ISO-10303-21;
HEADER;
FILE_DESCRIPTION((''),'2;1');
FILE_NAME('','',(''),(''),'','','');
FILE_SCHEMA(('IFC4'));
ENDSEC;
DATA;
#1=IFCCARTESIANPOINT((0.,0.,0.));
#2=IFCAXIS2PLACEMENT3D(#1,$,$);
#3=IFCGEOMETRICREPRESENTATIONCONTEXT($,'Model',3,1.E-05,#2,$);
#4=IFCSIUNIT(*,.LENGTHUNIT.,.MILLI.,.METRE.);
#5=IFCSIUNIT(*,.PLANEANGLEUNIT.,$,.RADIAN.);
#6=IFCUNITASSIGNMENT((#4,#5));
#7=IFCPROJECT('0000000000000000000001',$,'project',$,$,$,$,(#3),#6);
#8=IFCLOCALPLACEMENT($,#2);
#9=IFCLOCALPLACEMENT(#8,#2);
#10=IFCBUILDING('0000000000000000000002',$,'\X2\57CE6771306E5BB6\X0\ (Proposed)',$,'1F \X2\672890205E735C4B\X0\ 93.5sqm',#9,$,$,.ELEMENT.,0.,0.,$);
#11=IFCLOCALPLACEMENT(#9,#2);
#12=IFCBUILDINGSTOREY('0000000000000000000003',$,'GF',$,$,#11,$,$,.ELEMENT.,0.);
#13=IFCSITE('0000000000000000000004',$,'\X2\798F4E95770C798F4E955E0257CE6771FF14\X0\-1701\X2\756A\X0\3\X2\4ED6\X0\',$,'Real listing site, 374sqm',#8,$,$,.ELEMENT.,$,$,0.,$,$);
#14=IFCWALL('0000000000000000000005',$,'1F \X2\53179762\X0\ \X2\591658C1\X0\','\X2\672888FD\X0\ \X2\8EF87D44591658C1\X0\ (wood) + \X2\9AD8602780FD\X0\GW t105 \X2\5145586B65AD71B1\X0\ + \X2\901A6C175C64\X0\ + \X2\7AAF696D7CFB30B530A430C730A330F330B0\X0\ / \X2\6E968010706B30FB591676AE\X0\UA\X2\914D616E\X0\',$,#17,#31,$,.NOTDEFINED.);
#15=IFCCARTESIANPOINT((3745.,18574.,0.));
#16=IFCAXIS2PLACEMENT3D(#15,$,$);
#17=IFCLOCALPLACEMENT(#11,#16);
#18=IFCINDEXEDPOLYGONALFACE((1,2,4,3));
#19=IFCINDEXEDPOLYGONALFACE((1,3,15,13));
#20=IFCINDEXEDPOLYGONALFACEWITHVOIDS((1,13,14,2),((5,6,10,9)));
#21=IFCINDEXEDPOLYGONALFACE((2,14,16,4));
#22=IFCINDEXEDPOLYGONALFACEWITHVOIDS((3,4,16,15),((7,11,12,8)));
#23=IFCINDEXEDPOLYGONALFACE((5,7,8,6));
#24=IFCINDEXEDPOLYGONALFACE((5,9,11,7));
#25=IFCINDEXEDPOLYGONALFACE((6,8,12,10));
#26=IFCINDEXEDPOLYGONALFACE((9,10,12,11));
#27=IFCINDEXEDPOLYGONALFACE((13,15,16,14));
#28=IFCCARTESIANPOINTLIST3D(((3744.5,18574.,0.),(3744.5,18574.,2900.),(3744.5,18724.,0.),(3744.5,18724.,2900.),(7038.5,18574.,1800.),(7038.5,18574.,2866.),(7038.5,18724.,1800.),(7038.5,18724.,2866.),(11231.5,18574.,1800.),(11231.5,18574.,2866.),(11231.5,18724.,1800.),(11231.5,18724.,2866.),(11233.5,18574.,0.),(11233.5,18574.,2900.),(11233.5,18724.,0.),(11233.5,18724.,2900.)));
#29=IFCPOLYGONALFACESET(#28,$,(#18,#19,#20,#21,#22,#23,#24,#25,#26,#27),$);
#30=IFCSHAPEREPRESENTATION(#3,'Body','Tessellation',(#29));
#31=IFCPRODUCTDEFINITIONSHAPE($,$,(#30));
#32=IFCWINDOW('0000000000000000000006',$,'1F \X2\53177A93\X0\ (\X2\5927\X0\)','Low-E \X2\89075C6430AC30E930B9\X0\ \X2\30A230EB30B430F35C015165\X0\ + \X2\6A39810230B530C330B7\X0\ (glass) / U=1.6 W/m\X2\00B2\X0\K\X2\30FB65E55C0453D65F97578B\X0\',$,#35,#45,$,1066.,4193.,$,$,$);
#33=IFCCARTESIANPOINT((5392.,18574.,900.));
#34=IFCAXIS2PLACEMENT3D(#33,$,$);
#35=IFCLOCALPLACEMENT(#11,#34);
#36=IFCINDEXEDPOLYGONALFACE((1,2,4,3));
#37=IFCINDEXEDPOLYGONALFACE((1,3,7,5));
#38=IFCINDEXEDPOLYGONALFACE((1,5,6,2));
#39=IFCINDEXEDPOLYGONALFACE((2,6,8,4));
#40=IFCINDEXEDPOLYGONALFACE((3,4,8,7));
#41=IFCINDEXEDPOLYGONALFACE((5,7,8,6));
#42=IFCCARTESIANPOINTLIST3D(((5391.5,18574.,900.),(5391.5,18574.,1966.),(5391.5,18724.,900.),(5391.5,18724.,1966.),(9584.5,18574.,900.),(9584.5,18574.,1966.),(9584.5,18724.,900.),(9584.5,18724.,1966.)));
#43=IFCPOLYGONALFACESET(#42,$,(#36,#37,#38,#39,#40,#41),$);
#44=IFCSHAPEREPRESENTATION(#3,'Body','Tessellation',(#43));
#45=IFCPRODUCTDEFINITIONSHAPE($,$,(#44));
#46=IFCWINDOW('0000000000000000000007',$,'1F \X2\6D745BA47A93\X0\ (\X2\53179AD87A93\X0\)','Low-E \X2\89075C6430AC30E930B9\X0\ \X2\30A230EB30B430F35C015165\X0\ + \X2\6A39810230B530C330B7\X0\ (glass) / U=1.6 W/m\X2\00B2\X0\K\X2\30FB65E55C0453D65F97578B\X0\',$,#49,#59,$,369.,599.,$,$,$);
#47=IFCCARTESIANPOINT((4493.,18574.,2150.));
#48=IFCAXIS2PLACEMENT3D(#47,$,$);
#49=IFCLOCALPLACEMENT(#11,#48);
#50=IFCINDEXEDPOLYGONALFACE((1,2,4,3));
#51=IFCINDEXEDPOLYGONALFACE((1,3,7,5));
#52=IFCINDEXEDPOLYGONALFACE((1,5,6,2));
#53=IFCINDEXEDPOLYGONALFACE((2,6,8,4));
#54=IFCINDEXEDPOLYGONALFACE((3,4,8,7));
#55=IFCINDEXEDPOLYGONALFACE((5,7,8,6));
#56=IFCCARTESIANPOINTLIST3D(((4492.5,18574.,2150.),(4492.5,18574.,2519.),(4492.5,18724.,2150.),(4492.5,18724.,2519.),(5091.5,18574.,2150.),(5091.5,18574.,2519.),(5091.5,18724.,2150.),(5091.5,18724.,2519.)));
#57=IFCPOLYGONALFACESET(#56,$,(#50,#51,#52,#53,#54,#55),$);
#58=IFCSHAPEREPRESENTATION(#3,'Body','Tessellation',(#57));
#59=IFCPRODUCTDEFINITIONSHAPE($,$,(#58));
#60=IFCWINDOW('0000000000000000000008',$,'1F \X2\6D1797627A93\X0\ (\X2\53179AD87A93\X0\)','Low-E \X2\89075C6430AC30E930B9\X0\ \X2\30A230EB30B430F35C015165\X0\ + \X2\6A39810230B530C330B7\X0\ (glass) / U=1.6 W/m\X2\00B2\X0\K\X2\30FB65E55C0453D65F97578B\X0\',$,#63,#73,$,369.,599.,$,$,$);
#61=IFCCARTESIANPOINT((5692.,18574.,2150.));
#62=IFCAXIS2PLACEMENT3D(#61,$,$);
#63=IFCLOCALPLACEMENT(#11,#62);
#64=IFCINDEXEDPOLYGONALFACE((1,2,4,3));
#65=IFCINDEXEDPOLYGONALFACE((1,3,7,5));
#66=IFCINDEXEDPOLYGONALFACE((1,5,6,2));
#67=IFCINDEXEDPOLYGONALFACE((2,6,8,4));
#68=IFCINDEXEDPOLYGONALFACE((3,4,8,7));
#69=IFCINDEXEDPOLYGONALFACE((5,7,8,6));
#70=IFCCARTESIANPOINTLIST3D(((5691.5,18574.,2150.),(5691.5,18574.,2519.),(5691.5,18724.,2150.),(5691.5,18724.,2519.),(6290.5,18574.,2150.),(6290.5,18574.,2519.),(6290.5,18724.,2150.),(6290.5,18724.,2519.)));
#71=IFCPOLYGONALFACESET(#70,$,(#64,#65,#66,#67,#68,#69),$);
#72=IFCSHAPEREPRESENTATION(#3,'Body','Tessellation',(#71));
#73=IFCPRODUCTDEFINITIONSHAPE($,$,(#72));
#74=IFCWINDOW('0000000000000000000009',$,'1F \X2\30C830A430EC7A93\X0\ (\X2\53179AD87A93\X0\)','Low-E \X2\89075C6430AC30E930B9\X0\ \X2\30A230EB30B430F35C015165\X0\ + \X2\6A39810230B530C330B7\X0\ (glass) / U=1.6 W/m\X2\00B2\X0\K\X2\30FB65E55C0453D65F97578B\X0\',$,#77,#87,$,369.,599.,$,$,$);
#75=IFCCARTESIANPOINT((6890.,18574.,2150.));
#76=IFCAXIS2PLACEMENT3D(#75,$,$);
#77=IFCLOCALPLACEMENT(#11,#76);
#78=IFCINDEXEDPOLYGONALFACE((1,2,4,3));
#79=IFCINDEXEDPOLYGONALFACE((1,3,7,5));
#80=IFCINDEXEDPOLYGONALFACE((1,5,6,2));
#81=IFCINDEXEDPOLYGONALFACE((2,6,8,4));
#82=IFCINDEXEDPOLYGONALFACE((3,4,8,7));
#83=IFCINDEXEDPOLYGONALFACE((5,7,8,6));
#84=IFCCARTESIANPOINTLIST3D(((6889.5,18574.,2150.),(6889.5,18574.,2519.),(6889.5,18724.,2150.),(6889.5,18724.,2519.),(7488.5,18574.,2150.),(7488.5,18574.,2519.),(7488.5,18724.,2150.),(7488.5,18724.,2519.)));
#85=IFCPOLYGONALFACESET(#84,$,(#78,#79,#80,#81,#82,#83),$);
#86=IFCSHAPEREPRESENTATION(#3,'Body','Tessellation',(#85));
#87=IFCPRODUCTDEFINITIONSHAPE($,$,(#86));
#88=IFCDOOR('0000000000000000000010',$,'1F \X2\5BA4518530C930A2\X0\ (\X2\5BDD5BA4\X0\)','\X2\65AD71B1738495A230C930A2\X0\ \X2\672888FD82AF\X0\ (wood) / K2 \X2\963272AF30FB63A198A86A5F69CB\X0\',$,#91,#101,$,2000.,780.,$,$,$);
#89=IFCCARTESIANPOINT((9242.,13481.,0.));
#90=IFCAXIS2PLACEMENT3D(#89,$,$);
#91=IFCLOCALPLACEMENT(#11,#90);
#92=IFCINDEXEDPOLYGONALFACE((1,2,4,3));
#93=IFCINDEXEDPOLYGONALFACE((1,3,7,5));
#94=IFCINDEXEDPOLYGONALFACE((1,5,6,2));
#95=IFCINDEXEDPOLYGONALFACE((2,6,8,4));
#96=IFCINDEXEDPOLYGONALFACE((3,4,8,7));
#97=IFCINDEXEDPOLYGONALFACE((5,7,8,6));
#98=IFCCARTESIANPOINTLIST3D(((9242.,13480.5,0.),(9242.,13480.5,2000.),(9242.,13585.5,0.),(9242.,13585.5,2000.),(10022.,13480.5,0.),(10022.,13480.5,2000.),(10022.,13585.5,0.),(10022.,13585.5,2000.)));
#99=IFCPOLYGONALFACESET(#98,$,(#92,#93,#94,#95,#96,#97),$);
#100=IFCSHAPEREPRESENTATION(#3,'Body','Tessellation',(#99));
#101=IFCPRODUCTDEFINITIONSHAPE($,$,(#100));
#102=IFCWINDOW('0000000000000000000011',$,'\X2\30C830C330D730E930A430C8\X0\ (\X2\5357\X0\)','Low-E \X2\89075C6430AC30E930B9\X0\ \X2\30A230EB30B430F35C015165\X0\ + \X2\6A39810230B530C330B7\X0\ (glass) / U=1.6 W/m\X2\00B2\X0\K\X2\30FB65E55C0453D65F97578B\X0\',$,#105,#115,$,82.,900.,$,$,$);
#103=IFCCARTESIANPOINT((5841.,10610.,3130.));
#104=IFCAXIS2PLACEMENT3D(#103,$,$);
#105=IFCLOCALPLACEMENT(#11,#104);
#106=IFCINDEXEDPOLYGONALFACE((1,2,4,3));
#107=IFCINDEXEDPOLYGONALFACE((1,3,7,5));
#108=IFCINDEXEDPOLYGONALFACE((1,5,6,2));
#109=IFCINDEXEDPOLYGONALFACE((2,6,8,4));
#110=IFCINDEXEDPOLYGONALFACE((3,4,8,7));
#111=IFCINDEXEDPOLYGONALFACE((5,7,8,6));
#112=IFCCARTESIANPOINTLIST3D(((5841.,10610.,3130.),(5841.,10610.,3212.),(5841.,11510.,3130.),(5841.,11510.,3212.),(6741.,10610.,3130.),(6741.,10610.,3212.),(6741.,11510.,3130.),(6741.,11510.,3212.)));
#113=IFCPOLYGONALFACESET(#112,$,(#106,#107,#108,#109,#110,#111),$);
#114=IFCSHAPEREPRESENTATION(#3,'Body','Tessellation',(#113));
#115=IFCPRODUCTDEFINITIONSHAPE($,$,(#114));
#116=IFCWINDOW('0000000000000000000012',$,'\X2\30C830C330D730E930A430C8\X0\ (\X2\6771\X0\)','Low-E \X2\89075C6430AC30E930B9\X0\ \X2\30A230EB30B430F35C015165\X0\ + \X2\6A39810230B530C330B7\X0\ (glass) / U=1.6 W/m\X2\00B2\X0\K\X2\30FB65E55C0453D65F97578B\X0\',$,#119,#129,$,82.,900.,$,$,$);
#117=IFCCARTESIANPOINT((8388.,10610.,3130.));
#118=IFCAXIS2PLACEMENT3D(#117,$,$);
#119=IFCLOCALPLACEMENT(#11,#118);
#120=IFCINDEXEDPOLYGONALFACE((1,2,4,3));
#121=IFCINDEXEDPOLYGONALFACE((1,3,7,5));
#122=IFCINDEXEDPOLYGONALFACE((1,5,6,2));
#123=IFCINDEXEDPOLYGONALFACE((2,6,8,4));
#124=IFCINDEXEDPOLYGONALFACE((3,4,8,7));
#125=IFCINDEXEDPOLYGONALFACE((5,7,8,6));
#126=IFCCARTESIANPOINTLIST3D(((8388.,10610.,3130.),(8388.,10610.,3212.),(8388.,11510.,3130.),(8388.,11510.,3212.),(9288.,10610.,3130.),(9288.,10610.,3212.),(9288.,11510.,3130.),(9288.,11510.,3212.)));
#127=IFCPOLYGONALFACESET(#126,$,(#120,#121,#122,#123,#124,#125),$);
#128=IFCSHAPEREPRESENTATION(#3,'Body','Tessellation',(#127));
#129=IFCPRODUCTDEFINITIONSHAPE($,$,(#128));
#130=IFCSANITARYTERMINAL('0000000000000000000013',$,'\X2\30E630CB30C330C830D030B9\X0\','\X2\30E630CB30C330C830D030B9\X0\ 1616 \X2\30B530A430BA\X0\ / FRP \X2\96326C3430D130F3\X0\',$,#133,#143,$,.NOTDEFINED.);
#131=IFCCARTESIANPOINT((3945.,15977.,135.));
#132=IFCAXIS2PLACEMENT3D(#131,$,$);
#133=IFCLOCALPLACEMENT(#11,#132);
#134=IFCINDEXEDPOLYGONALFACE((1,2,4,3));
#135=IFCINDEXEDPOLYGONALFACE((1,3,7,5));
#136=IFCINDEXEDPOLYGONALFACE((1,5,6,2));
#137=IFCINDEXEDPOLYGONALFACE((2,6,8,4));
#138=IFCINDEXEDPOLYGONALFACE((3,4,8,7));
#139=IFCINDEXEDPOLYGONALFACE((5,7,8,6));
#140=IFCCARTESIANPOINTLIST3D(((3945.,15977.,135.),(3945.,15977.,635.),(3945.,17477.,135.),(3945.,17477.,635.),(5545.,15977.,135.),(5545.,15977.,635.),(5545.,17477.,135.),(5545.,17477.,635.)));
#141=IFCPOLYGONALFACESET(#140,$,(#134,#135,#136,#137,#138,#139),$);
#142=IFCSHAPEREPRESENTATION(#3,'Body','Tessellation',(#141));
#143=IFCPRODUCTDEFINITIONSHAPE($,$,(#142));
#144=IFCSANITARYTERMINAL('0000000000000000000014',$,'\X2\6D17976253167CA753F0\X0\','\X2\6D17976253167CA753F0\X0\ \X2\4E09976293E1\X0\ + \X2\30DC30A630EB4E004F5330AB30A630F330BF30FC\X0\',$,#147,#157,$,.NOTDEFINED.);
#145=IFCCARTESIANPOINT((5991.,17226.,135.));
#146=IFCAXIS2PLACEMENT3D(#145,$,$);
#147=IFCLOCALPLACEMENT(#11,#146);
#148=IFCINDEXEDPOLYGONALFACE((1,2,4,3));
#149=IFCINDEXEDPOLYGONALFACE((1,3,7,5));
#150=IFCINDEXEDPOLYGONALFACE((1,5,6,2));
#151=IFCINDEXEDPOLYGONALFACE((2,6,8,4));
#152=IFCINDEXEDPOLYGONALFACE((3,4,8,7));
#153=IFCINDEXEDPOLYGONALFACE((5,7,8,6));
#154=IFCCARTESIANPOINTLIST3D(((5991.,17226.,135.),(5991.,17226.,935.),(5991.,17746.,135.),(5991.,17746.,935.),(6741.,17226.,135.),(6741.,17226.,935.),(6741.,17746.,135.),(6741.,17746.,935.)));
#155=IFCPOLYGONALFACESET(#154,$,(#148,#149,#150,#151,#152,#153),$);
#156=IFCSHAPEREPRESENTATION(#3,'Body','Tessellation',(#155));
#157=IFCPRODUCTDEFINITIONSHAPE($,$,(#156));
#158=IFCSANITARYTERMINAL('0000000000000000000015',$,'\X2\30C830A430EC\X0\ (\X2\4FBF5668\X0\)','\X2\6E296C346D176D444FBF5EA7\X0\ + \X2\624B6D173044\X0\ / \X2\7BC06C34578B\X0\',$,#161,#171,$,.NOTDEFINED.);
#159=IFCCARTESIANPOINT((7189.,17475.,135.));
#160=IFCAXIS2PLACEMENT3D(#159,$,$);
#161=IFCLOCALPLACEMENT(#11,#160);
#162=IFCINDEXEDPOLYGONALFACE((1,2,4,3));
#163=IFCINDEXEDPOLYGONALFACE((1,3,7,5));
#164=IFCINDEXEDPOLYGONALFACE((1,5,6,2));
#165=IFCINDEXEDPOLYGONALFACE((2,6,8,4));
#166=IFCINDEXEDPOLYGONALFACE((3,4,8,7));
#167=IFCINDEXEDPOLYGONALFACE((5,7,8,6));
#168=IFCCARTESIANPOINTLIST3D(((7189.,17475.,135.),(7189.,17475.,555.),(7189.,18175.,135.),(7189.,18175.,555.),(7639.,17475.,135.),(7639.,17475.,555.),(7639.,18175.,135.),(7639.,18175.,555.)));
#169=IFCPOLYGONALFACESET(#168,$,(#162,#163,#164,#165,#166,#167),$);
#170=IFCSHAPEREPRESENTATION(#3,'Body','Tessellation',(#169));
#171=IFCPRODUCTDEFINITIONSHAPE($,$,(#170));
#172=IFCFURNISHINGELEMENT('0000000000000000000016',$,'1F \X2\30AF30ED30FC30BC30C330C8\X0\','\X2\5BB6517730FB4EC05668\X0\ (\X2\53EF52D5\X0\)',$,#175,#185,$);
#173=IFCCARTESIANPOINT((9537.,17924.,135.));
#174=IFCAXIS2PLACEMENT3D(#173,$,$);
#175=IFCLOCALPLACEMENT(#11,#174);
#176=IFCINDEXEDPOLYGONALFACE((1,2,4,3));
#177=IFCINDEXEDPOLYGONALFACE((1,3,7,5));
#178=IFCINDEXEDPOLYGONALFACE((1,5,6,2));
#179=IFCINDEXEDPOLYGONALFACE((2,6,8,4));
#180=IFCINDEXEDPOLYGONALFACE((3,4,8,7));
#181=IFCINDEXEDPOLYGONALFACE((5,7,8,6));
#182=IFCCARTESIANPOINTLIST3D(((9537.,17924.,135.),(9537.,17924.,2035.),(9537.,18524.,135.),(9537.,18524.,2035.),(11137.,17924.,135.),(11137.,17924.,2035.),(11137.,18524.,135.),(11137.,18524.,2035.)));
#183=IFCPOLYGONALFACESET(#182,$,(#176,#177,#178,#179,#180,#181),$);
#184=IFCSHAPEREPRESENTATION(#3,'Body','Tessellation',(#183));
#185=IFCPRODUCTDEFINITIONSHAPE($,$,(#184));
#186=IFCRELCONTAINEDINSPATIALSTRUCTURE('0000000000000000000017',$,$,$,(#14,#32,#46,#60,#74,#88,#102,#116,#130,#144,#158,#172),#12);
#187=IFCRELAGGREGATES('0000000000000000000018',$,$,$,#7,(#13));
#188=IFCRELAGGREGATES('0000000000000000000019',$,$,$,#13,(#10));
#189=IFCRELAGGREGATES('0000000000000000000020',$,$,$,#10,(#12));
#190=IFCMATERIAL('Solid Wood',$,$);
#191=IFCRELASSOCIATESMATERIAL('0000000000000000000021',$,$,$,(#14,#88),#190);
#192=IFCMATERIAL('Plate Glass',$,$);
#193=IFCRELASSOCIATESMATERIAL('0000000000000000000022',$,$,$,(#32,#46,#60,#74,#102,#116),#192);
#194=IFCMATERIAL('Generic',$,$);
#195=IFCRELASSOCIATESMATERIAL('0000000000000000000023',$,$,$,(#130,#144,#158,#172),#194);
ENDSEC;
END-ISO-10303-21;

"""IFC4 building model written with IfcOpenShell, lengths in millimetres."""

from ifc_helpers import new_model, si_unit, frame, frame_2d, origin, place, context, project, spatial, rectangle, extrude, material, element, fill, save


model = new_model("IFC4")

# Units and contexts
model_context = context("Model", 3, precision=1e-05, world=origin())
ifc_project = project(units=[si_unit("LENGTHUNIT", "METRE", prefix="MILLI"), si_unit("PLANEANGLEUNIT", "RADIAN")], contexts=[model_context])

# Site, building, storey
site_placement = place(None, origin())
site = spatial("IfcSite", under=ifc_project, at=site_placement, Name="福井県福井市城東４-1701番3他", ObjectType="Real listing site, 374sqm", CompositionType="ELEMENT", RefElevation=0.0)
building_placement = place(site_placement, origin())
building = spatial("IfcBuilding", under=site, at=building_placement, Name="城東の家 (Proposed)", ObjectType="1F 木造平屋 93.5sqm", CompositionType="ELEMENT", ElevationOfRefHeight=0.0, ElevationOfTerrain=0.0)
storey_placement = place(building_placement, origin())
storey = spatial("IfcBuildingStorey", under=building, at=storey_placement, Name="GF", CompositionType="ELEMENT", Elevation=0.0)

# Shared definitions
ifc_material_1 = material(Name="Solid Wood")

# Wall, openings, windows
wall_1_placement = place(storey_placement, frame((3745.0, 18574.0, 0.0)))
wall_1 = element("IfcWall", 1, at=wall_1_placement, inside=storey, material=ifc_material_1, Name="1F 北面 外壁", Description="木製 軸組外壁 (wood) + 高性能GW t105 充填断熱 + 通気層 + 窯業系サイディング / 準耐火・外皮UA配慮", PredefinedType="NOTDEFINED", context=model_context, shape_type="SweptSolid", body=[
    extrude(rectangle(XDim=7489.0, YDim=150.0, at=frame_2d((3744.0, 75.0))), frame((3745.0, 18574.0, 0.0)), (0.0, 0.0, 1.0), 2900.0),
])
opening_1_placement = place(storey_placement, frame((5392.0, 18574.0, 900.0)))
opening_1 = element("IfcOpeningElement", 2, at=opening_1_placement, cuts=wall_1, PredefinedType="NOTDEFINED", context=model_context, shape_type="SweptSolid", body=[
    extrude(rectangle(XDim=4193.0, YDim=150.0, at=frame_2d((2096.0, 75.0))), frame((5392.0, 18574.0, 900.0)), (0.0, 0.0, 1.0), 1066.0),
])
opening_2_placement = place(storey_placement, frame((4493.0, 18574.0, 2150.0)))
opening_2 = element("IfcOpeningElement", 3, at=opening_2_placement, cuts=wall_1, PredefinedType="NOTDEFINED", context=model_context, shape_type="SweptSolid", body=[
    extrude(rectangle(XDim=599.0, YDim=150.0, at=frame_2d((299.0, 75.0))), frame((4493.0, 18574.0, 2150.0)), (0.0, 0.0, 1.0), 369.0),
])
opening_3_placement = place(storey_placement, frame((5692.0, 18574.0, 2150.0)))
opening_3 = element("IfcOpeningElement", 4, at=opening_3_placement, cuts=wall_1, PredefinedType="NOTDEFINED", context=model_context, shape_type="SweptSolid", body=[
    extrude(rectangle(XDim=599.0, YDim=150.0, at=frame_2d((299.0, 75.0))), frame((5692.0, 18574.0, 2150.0)), (0.0, 0.0, 1.0), 369.0),
])
opening_4_placement = place(storey_placement, frame((6890.0, 18574.0, 2150.0)))
opening_4 = element("IfcOpeningElement", 5, at=opening_4_placement, cuts=wall_1, PredefinedType="NOTDEFINED", context=model_context, shape_type="SweptSolid", body=[
    extrude(rectangle(XDim=599.0, YDim=150.0, at=frame_2d((299.0, 75.0))), frame((6890.0, 18574.0, 2150.0)), (0.0, 0.0, 1.0), 369.0),
])
ifc_material_2 = material(Name="Plate Glass")
window_1_placement = place(storey_placement, frame((5392.0, 18574.0, 900.0)))
window_1 = element("IfcWindow", 6, at=window_1_placement, inside=storey, material=ifc_material_2, Name="1F 北窓 (大)", Description="Low-E 複層ガラス アルゴン封入 + 樹脂サッシ (glass) / U=1.6 W/m²K・日射取得型", OverallHeight=1066.0, OverallWidth=4193.0, context=model_context, shape_type="SweptSolid", body=[
    extrude(rectangle(XDim=4193.0, YDim=150.0, at=frame_2d((2096.0, 75.0))), frame((5392.0, 18574.0, 900.0)), (0.0, 0.0, 1.0), 1066.0),
])
fill(opening_1, window_1)
window_2_placement = place(storey_placement, frame((4493.0, 18574.0, 2150.0)))
window_2 = element("IfcWindow", 7, at=window_2_placement, inside=storey, material=ifc_material_2, Name="1F 浴室窓 (北高窓)", Description="Low-E 複層ガラス アルゴン封入 + 樹脂サッシ (glass) / U=1.6 W/m²K・日射取得型", OverallHeight=369.0, OverallWidth=599.0, context=model_context, shape_type="SweptSolid", body=[
    extrude(rectangle(XDim=599.0, YDim=150.0, at=frame_2d((299.0, 75.0))), frame((4493.0, 18574.0, 2150.0)), (0.0, 0.0, 1.0), 369.0),
])
fill(opening_2, window_2)
window_3_placement = place(storey_placement, frame((5692.0, 18574.0, 2150.0)))
window_3 = element("IfcWindow", 8, at=window_3_placement, inside=storey, material=ifc_material_2, Name="1F 洗面窓 (北高窓)", Description="Low-E 複層ガラス アルゴン封入 + 樹脂サッシ (glass) / U=1.6 W/m²K・日射取得型", OverallHeight=369.0, OverallWidth=599.0, context=model_context, shape_type="SweptSolid", body=[
    extrude(rectangle(XDim=599.0, YDim=150.0, at=frame_2d((299.0, 75.0))), frame((5692.0, 18574.0, 2150.0)), (0.0, 0.0, 1.0), 369.0),
])
fill(opening_3, window_3)
window_4_placement = place(storey_placement, frame((6890.0, 18574.0, 2150.0)))
window_4 = element("IfcWindow", 9, at=window_4_placement, inside=storey, material=ifc_material_2, Name="1F トイレ窓 (北高窓)", Description="Low-E 複層ガラス アルゴン封入 + 樹脂サッシ (glass) / U=1.6 W/m²K・日射取得型", OverallHeight=369.0, OverallWidth=599.0, context=model_context, shape_type="SweptSolid", body=[
    extrude(rectangle(XDim=599.0, YDim=150.0, at=frame_2d((299.0, 75.0))), frame((6890.0, 18574.0, 2150.0)), (0.0, 0.0, 1.0), 369.0),
])
fill(opening_4, window_4)

# Door
door_1_placement = place(storey_placement, frame((9242.0, 13481.0, 0.0)))
element("IfcDoor", 10, at=door_1_placement, inside=storey, material=ifc_material_1, Name="1F 室内ドア (寝室)", Description="断熱玄関ドア 木製芯 (wood) / K2 防犯・採風機構", OverallHeight=2000.0, OverallWidth=780.0, context=model_context, shape_type="SweptSolid", body=[
    extrude(rectangle(XDim=780.0, YDim=105.0, at=frame_2d((390.0, 52.0))), frame((9242.0, 13481.0, 0.0)), (0.0, 0.0, 1.0), 2000.0),
])

# Windows
window_5_placement = place(storey_placement, frame((5841.0, 10610.0, 3130.0)))
element("IfcWindow", 11, at=window_5_placement, inside=storey, material=ifc_material_2, Name="トップライト (南)", Description="Low-E 複層ガラス アルゴン封入 + 樹脂サッシ (glass) / U=1.6 W/m²K・日射取得型", OverallHeight=82.0, OverallWidth=900.0, context=model_context, shape_type="SweptSolid", body=[
    extrude(rectangle(XDim=900.0, YDim=900.0, at=frame_2d((450.0, 450.0))), frame((5841.0, 10610.0, 3130.0)), (0.0, 0.0, 1.0), 82.0),
])
window_6_placement = place(storey_placement, frame((8388.0, 10610.0, 3130.0)))
element("IfcWindow", 12, at=window_6_placement, inside=storey, material=ifc_material_2, Name="トップライト (東)", Description="Low-E 複層ガラス アルゴン封入 + 樹脂サッシ (glass) / U=1.6 W/m²K・日射取得型", OverallHeight=82.0, OverallWidth=900.0, context=model_context, shape_type="SweptSolid", body=[
    extrude(rectangle(XDim=900.0, YDim=900.0, at=frame_2d((450.0, 450.0))), frame((8388.0, 10610.0, 3130.0)), (0.0, 0.0, 1.0), 82.0),
])

# Sanitary terminals
ifc_material_3 = material(Name="Generic")
sanitary_terminal_1_placement = place(storey_placement, frame((3945.0, 15977.0, 135.0)))
element("IfcSanitaryTerminal", 13, at=sanitary_terminal_1_placement, inside=storey, material=ifc_material_3, Name="ユニットバス", Description="ユニットバス 1616 サイズ / FRP 防水パン", PredefinedType="NOTDEFINED", context=model_context, shape_type="SweptSolid", body=[
    extrude(rectangle(XDim=1600.0, YDim=1500.0, at=frame_2d((800.0, 750.0))), frame((3945.0, 15977.0, 135.0)), (0.0, 0.0, 1.0), 500.0),
])
sanitary_terminal_2_placement = place(storey_placement, frame((5991.0, 17226.0, 135.0)))
element("IfcSanitaryTerminal", 14, at=sanitary_terminal_2_placement, inside=storey, material=ifc_material_3, Name="洗面化粧台", Description="洗面化粧台 三面鏡 + ボウル一体カウンター", PredefinedType="NOTDEFINED", context=model_context, shape_type="SweptSolid", body=[
    extrude(rectangle(XDim=750.0, YDim=520.0, at=frame_2d((375.0, 260.0))), frame((5991.0, 17226.0, 135.0)), (0.0, 0.0, 1.0), 800.0),
])
sanitary_terminal_3_placement = place(storey_placement, frame((7189.0, 17475.0, 135.0)))
element("IfcSanitaryTerminal", 15, at=sanitary_terminal_3_placement, inside=storey, material=ifc_material_3, Name="トイレ (便器)", Description="温水洗浄便座 + 手洗い / 節水型", PredefinedType="NOTDEFINED", context=model_context, shape_type="SweptSolid", body=[
    extrude(rectangle(XDim=450.0, YDim=700.0, at=frame_2d((225.0, 350.0))), frame((7189.0, 17475.0, 135.0)), (0.0, 0.0, 1.0), 420.0),
])

# Furnishing element
furnishing_1_placement = place(storey_placement, frame((9537.0, 17924.0, 135.0)))
element("IfcFurnishingElement", 16, at=furnishing_1_placement, inside=storey, material=ifc_material_3, Name="1F クローゼット", Description="家具・什器 (可動)", context=model_context, shape_type="SweptSolid", body=[
    extrude(rectangle(XDim=1600.0, YDim=600.0, at=frame_2d((800.0, 300.0))), frame((9537.0, 17924.0, 135.0)), (0.0, 0.0, 1.0), 1900.0),
])

save(model, "model.ifc")
